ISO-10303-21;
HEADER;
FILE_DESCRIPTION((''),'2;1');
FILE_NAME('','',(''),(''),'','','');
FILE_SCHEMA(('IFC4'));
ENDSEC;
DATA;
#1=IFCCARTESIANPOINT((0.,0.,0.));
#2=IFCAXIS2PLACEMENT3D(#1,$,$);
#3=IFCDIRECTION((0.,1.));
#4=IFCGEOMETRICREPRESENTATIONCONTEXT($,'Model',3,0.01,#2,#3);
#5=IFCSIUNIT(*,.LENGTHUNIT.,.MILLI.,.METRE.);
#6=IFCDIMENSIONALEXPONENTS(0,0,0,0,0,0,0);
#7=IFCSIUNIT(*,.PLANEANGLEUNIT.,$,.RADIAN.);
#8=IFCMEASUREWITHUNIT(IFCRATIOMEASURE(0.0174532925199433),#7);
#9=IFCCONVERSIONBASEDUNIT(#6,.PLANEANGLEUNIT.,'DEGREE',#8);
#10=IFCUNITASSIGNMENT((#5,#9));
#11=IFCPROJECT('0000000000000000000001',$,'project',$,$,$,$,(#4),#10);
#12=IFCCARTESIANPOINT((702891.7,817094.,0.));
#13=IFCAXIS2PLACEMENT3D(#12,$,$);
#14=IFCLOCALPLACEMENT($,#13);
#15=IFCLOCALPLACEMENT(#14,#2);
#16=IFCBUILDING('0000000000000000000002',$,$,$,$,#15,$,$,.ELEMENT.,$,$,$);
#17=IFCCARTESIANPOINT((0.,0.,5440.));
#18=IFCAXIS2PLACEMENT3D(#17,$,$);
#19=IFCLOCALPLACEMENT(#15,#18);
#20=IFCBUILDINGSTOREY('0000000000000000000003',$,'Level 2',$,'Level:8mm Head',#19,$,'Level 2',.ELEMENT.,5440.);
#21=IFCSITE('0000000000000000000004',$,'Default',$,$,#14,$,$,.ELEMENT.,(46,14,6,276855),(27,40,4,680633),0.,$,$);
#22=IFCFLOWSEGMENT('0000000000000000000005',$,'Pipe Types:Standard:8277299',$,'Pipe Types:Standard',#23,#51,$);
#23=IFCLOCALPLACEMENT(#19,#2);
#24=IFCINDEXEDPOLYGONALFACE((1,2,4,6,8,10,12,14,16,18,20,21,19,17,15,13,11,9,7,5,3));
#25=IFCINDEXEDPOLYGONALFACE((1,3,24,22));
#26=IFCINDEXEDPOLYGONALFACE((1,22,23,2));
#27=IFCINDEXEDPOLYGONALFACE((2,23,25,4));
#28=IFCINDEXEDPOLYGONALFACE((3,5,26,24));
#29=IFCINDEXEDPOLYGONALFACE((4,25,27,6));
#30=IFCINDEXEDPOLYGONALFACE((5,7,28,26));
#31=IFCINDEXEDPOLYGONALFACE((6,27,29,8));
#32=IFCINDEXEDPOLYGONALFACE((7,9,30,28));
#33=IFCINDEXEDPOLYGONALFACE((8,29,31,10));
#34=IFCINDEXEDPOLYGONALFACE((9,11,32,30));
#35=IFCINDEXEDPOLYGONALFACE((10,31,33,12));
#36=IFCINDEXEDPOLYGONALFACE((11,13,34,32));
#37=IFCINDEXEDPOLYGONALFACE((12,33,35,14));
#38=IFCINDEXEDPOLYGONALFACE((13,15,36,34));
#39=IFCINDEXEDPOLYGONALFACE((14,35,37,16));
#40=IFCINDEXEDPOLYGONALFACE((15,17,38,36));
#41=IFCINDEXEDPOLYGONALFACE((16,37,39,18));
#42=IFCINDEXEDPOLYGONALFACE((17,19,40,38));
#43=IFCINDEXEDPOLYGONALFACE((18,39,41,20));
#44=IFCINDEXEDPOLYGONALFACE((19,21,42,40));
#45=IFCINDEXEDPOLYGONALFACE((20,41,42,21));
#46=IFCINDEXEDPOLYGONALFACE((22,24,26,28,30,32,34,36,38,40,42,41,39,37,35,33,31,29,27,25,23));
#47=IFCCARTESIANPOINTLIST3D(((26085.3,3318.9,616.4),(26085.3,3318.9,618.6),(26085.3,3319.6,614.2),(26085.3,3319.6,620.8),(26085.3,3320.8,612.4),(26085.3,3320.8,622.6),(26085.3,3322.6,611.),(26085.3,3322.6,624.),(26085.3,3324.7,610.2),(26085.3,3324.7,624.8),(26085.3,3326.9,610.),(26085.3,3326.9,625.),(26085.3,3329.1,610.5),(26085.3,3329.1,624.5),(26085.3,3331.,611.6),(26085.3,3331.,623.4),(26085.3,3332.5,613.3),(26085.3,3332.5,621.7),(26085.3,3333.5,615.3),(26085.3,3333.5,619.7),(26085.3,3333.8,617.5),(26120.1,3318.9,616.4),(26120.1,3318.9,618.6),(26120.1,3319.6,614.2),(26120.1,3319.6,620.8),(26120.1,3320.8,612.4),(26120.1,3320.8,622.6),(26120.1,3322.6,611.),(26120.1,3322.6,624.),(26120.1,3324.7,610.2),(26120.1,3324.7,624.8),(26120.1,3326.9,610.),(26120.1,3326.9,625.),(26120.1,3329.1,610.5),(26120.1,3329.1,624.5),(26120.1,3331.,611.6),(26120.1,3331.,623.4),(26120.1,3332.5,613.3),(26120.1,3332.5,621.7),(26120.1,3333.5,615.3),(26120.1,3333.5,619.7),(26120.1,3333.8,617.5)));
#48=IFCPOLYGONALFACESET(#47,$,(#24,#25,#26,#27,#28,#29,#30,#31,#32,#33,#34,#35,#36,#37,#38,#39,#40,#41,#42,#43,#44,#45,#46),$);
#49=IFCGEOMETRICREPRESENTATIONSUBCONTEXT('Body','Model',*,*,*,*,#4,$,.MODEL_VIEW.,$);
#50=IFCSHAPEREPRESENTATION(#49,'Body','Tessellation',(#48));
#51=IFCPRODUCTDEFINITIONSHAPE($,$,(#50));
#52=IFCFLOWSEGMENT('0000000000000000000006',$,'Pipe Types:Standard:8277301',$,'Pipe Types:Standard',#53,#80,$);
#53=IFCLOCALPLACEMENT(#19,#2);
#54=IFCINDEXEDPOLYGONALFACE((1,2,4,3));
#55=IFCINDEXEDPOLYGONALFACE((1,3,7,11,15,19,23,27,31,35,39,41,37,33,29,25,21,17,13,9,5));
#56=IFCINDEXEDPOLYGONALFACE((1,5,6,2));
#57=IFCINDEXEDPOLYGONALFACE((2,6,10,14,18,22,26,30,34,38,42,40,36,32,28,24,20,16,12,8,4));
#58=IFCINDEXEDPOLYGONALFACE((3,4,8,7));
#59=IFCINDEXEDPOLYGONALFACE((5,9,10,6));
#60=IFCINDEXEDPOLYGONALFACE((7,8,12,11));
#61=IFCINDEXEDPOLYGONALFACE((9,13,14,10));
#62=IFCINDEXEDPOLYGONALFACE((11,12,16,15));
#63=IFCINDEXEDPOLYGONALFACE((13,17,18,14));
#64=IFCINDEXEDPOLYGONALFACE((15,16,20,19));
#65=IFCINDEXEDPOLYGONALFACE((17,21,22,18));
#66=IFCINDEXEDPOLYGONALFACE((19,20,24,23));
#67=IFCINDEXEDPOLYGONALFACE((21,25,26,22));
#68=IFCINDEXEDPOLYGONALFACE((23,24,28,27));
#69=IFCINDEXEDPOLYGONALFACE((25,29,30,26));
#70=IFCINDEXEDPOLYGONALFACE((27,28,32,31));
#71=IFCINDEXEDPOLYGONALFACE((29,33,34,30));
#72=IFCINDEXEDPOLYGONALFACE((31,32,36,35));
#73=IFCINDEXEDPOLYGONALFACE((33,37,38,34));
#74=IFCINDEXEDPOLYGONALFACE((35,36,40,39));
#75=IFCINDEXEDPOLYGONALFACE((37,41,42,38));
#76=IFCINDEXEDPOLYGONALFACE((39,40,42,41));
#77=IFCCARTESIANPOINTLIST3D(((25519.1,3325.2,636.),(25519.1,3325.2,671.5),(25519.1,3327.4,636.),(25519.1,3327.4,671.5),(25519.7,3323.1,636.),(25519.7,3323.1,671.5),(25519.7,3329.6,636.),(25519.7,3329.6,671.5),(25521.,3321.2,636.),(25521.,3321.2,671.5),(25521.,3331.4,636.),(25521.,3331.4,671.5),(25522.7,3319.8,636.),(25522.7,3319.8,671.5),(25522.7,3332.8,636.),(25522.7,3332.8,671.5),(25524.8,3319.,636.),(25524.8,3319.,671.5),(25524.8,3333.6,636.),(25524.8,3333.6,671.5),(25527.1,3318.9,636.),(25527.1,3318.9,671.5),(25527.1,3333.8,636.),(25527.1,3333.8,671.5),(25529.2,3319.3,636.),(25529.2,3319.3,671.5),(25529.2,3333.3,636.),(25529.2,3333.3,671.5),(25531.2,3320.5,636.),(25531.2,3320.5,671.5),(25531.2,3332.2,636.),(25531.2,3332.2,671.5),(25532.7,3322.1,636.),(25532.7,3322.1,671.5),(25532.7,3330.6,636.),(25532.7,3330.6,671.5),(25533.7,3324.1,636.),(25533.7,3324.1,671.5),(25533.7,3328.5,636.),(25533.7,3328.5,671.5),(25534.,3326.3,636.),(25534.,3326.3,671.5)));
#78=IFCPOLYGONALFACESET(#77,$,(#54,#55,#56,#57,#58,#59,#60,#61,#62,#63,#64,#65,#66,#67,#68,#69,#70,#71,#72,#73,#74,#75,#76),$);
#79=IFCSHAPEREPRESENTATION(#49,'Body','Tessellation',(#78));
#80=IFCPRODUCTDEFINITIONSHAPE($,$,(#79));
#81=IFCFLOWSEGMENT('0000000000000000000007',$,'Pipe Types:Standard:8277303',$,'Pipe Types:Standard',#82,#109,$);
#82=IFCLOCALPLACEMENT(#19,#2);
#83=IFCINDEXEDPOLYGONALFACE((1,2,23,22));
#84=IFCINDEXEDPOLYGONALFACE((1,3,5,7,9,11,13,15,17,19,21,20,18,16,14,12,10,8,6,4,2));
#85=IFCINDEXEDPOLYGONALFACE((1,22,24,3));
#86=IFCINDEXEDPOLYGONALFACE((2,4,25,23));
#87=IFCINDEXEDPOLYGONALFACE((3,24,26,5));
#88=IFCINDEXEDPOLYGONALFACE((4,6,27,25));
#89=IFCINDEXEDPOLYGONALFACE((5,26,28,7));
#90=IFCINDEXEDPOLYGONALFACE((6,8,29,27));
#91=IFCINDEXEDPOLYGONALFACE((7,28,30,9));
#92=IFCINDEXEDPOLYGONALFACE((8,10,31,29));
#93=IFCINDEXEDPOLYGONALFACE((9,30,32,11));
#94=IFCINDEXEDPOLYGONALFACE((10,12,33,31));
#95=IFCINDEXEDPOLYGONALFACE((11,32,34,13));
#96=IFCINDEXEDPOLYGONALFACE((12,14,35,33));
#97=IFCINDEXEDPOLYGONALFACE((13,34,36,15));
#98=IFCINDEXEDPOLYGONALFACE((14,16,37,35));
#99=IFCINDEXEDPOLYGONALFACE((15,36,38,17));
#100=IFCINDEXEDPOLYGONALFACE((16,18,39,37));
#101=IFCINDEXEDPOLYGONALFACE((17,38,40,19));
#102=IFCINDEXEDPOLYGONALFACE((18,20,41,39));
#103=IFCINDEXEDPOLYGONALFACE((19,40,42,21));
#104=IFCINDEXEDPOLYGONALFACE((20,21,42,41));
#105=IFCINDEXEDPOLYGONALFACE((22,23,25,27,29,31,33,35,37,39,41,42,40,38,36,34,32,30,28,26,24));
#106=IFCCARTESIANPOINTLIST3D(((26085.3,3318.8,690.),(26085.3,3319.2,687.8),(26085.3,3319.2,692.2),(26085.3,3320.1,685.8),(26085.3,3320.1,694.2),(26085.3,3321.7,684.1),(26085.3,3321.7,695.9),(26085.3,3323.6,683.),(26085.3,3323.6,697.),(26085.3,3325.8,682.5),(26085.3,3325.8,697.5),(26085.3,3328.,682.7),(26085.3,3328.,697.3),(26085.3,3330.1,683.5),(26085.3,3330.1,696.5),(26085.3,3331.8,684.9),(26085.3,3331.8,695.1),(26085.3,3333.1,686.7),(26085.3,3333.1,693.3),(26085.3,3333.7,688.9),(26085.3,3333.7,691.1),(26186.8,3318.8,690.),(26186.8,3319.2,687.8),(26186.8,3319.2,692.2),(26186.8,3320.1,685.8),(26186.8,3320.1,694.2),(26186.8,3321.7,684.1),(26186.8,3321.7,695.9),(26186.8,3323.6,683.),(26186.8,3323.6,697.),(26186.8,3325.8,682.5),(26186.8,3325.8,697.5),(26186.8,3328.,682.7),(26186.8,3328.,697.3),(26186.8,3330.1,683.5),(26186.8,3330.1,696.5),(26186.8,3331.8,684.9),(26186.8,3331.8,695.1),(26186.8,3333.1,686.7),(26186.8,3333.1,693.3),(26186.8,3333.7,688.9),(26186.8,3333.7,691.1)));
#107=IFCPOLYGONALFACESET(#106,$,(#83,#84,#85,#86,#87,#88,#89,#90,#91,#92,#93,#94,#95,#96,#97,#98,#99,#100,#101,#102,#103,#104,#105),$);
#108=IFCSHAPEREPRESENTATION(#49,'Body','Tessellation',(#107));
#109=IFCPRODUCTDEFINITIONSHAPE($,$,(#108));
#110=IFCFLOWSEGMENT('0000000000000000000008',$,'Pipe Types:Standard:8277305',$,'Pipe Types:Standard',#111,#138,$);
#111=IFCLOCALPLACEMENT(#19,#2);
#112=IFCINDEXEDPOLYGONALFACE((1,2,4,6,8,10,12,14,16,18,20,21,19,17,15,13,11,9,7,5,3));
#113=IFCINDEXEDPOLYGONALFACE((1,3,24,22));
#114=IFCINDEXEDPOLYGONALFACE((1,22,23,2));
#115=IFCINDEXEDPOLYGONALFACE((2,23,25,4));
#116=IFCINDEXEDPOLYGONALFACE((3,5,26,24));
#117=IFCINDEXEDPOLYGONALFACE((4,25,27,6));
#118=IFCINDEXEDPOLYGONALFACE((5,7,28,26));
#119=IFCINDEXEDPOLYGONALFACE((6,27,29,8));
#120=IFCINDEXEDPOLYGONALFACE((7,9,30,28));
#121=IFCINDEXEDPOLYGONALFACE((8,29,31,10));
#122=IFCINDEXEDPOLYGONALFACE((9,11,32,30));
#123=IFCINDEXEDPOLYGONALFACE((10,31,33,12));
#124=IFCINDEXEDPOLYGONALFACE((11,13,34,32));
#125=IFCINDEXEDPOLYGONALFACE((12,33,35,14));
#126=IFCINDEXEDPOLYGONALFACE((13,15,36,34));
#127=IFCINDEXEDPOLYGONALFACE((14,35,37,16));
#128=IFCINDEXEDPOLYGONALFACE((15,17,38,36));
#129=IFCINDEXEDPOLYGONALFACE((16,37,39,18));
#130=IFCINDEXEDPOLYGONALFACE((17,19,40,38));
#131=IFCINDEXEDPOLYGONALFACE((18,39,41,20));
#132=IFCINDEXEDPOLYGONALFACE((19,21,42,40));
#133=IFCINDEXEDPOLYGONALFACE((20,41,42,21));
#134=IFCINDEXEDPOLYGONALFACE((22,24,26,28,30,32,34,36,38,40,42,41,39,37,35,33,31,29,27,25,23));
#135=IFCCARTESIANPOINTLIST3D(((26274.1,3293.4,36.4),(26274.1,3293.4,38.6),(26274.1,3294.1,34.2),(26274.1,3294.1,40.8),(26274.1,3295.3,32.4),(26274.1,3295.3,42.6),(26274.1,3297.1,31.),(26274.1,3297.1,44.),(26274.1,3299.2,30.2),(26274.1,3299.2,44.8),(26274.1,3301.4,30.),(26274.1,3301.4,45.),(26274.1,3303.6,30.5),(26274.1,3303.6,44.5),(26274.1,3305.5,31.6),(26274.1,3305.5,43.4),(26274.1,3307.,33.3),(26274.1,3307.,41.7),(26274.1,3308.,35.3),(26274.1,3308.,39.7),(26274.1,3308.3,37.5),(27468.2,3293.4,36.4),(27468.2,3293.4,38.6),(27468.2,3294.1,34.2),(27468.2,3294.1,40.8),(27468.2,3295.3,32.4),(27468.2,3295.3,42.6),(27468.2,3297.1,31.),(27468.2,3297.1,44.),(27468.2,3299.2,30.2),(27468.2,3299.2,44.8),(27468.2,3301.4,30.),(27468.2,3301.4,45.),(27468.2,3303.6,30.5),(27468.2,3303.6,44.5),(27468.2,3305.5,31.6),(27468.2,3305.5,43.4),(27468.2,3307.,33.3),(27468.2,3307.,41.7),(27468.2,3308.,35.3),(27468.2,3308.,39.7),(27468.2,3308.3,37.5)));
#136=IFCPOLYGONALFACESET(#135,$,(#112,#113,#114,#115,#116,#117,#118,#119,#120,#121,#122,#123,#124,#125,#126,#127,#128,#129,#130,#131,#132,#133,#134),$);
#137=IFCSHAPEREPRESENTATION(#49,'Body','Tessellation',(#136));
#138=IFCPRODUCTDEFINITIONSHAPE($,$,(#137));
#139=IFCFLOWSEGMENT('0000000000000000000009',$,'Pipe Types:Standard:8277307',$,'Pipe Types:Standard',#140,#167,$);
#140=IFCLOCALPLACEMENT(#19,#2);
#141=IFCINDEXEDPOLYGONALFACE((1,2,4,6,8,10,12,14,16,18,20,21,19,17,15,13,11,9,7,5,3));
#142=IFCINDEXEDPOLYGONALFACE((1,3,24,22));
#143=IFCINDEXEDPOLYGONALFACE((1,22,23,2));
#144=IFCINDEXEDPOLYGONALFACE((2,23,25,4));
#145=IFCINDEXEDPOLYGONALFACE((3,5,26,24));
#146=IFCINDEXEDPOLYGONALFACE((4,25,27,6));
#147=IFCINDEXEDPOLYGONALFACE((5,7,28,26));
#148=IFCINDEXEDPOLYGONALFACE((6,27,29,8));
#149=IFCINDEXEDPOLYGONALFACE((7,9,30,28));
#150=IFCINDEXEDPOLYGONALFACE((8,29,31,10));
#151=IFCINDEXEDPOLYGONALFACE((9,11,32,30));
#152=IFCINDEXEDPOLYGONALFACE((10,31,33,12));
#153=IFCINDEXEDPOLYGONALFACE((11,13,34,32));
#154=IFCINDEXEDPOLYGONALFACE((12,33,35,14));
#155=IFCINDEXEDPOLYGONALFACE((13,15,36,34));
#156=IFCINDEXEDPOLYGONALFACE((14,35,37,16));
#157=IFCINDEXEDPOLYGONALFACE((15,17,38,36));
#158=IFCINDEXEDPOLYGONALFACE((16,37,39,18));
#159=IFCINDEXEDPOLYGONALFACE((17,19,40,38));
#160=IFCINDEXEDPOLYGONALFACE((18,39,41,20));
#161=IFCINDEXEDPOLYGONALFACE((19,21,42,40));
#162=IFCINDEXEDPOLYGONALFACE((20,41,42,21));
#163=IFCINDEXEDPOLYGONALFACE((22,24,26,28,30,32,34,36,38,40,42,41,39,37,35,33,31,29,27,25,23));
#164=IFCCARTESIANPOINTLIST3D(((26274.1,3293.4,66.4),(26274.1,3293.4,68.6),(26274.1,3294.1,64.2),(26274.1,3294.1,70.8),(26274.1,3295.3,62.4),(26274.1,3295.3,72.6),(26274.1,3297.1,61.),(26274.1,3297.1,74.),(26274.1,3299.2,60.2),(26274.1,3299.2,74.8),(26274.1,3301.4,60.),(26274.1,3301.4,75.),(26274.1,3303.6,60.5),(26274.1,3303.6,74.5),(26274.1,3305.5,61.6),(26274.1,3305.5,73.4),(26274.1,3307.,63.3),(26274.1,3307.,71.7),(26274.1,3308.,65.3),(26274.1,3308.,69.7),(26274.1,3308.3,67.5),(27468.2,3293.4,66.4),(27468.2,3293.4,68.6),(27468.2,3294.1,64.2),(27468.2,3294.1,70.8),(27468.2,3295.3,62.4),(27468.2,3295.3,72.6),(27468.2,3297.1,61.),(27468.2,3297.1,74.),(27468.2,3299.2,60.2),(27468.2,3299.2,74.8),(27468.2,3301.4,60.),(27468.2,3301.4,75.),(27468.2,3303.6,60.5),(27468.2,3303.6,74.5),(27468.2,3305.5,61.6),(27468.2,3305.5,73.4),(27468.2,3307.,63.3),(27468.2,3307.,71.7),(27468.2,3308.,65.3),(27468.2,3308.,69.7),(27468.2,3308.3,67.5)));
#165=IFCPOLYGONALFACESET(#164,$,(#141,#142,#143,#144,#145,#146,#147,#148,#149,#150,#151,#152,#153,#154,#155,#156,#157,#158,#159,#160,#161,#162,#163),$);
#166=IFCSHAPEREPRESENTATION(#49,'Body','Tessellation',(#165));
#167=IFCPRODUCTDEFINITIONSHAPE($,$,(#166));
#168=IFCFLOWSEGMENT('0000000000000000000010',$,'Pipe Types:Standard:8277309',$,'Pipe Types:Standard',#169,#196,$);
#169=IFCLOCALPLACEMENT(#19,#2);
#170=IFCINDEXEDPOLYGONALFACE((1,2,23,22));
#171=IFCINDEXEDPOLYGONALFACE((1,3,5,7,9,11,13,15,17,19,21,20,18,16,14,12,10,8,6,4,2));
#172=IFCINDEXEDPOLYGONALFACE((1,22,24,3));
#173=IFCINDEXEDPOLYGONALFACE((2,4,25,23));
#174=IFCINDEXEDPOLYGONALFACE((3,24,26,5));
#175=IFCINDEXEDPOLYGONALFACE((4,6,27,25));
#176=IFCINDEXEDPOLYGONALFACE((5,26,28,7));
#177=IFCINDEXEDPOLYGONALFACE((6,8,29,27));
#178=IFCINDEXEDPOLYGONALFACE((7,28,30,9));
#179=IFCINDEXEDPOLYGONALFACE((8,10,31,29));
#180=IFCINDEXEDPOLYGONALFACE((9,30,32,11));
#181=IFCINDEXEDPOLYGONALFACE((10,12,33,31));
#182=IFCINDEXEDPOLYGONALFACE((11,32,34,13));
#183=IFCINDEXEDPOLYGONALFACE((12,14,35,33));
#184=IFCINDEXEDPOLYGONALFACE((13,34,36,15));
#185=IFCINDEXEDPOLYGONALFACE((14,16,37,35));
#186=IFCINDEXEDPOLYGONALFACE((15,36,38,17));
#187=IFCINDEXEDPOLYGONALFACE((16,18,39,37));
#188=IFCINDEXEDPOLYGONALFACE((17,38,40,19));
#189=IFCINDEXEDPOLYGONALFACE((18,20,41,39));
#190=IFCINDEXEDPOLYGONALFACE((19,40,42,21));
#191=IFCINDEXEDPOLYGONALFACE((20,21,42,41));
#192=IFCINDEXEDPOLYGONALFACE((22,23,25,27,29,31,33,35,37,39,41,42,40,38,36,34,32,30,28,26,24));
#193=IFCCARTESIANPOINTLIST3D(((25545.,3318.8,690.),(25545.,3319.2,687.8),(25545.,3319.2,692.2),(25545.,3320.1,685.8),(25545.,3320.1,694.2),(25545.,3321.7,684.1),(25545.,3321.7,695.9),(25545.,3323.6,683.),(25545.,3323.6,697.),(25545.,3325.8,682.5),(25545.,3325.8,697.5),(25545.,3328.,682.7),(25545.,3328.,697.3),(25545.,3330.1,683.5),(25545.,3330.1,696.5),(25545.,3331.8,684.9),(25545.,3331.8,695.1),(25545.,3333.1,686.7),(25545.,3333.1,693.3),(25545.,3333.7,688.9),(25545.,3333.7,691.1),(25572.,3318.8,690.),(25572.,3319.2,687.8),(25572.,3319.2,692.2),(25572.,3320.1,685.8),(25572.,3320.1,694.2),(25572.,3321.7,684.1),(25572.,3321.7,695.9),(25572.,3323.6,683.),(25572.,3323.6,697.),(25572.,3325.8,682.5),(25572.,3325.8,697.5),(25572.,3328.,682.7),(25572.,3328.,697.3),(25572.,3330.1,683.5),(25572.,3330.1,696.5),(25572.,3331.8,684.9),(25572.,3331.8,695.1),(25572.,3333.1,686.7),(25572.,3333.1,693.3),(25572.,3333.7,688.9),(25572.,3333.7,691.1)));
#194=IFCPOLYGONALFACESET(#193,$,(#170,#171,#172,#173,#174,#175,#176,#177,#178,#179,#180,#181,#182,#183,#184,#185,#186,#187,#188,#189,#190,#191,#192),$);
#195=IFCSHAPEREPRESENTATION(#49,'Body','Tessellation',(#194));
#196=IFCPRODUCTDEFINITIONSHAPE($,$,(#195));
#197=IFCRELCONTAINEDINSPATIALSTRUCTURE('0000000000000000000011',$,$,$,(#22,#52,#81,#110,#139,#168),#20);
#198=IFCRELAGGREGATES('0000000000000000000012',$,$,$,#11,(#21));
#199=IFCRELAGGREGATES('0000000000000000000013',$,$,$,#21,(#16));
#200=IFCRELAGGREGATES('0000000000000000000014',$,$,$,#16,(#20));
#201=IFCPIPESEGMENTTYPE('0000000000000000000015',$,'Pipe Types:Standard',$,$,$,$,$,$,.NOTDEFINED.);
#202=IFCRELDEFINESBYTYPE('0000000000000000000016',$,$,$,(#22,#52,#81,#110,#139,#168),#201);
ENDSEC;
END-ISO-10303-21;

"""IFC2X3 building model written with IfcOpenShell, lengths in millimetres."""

from ifc_helpers import new_model, entity, si_unit, converted_unit, direction, frame, frame_2d, origin, origin_2d_with_axis, place, context, subcontext, project, spatial, circle, extrude, type_object, element, save


model = new_model("IFC2X3")

# Units and contexts
model_context = context("Model", 3, precision=0.01, world=origin(), true_north=direction((0.0, 1.0)))
body_context = subcontext(model_context, "Body", "Model", "MODEL_VIEW")
ifc_project = project(units=[si_unit("LENGTHUNIT", "METRE", prefix="MILLI"), converted_unit("PLANEANGLEUNIT", "DEGREE", entity("IfcRatioMeasure", 0.0174532925199433), si_unit("PLANEANGLEUNIT", "RADIAN"), dimensions=[0, 0, 0, 0, 0, 0, 0])], contexts=[model_context])

# Site, building, storey
site_placement = place(None, frame((702891.7, 817094.0, 0.0)))
site = spatial("IfcSite", under=ifc_project, at=site_placement, Name="Default", CompositionType="ELEMENT", RefLatitude=(46, 14, 6, 276855), RefLongitude=(27, 40, 4, 680633), RefElevation=0.0)
building_placement = place(site_placement, origin())
building = spatial("IfcBuilding", under=site, at=building_placement, CompositionType="ELEMENT")
storey_placement = place(building_placement, frame((0.0, 0.0, 5440.0)))
storey = spatial("IfcBuildingStorey", under=building, at=storey_placement, Name="Level 2", ObjectType="Level:8mm Head", LongName="Level 2", CompositionType="ELEMENT", Elevation=5440.0)

# Flow segments
pipe_segment_type = type_object("IfcPipeSegmentType", Name="Pipe Types:Standard", PredefinedType="NOTDEFINED")
flow_segment_1_placement = place(storey_placement, origin())
element("IfcFlowSegment", 1, at=flow_segment_1_placement, inside=storey, type_object=pipe_segment_type, Name="Pipe Types:Standard:8277299", ObjectType="Pipe Types:Standard", context=body_context, shape_type="SweptSolid", body=[
    extrude(circle(Radius=7.5, at=frame_2d((0.0, 0.0), x_axis=(1.0, 0.0))), frame((26085.3, 3326.3, 617.5), z_axis=(1.0, 0.0, 0.0), x_axis=(0.0, 1.0, 0.0)), (0.0, 0.0, 1.0), 34.8),
])
flow_segment_2_placement = place(storey_placement, origin())
element("IfcFlowSegment", 2, at=flow_segment_2_placement, inside=storey, type_object=pipe_segment_type, Name="Pipe Types:Standard:8277301", ObjectType="Pipe Types:Standard", context=body_context, shape_type="SweptSolid", body=[
    extrude(circle(Radius=7.5, at=origin_2d_with_axis()), frame((25526.5, 3326.3, 636.0)), (0.0, 0.0, 1.0), 35.5),
])
flow_segment_3_placement = place(storey_placement, origin())
element("IfcFlowSegment", 3, at=flow_segment_3_placement, inside=storey, type_object=pipe_segment_type, Name="Pipe Types:Standard:8277303", ObjectType="Pipe Types:Standard", context=body_context, shape_type="SweptSolid", body=[
    extrude(circle(Radius=7.5, at=origin_2d_with_axis()), frame((26085.3, 3326.3, 690.0), z_axis=(1.0, 0.0, 0.0), x_axis=(0.0, -1.0, 0.0)), (0.0, 0.0, 1.0), 101.5),
])
flow_segment_4_placement = place(storey_placement, origin())
element("IfcFlowSegment", 4, at=flow_segment_4_placement, inside=storey, type_object=pipe_segment_type, Name="Pipe Types:Standard:8277305", ObjectType="Pipe Types:Standard", context=body_context, shape_type="SweptSolid", body=[
    extrude(circle(Radius=7.5, at=frame_2d((0.0, 0.0), x_axis=(1.0, 0.0))), frame((26274.1, 3300.8, 37.5), z_axis=(1.0, 0.0, 0.0), x_axis=(0.0, 1.0, 0.0)), (0.0, 0.0, 1.0), 1194.1),
])
flow_segment_5_placement = place(storey_placement, origin())
element("IfcFlowSegment", 5, at=flow_segment_5_placement, inside=storey, type_object=pipe_segment_type, Name="Pipe Types:Standard:8277307", ObjectType="Pipe Types:Standard", context=body_context, shape_type="SweptSolid", body=[
    extrude(circle(Radius=7.5, at=frame_2d((0.0, 0.0), x_axis=(1.0, 0.0))), frame((26274.1, 3300.8, 67.5), z_axis=(1.0, 0.0, 0.0), x_axis=(0.0, 1.0, 0.0)), (0.0, 0.0, 1.0), 1194.1),
])
flow_segment_6_placement = place(storey_placement, origin())
element("IfcFlowSegment", 6, at=flow_segment_6_placement, inside=storey, type_object=pipe_segment_type, Name="Pipe Types:Standard:8277309", ObjectType="Pipe Types:Standard", context=body_context, shape_type="SweptSolid", body=[
    extrude(circle(Radius=7.5, at=origin_2d_with_axis()), frame((25545.0, 3326.3, 690.0), z_axis=(1.0, 0.0, 0.0), x_axis=(0.0, -1.0, 0.0)), (0.0, 0.0, 1.0), 27.0),
])

save(model, "model.ifc")
